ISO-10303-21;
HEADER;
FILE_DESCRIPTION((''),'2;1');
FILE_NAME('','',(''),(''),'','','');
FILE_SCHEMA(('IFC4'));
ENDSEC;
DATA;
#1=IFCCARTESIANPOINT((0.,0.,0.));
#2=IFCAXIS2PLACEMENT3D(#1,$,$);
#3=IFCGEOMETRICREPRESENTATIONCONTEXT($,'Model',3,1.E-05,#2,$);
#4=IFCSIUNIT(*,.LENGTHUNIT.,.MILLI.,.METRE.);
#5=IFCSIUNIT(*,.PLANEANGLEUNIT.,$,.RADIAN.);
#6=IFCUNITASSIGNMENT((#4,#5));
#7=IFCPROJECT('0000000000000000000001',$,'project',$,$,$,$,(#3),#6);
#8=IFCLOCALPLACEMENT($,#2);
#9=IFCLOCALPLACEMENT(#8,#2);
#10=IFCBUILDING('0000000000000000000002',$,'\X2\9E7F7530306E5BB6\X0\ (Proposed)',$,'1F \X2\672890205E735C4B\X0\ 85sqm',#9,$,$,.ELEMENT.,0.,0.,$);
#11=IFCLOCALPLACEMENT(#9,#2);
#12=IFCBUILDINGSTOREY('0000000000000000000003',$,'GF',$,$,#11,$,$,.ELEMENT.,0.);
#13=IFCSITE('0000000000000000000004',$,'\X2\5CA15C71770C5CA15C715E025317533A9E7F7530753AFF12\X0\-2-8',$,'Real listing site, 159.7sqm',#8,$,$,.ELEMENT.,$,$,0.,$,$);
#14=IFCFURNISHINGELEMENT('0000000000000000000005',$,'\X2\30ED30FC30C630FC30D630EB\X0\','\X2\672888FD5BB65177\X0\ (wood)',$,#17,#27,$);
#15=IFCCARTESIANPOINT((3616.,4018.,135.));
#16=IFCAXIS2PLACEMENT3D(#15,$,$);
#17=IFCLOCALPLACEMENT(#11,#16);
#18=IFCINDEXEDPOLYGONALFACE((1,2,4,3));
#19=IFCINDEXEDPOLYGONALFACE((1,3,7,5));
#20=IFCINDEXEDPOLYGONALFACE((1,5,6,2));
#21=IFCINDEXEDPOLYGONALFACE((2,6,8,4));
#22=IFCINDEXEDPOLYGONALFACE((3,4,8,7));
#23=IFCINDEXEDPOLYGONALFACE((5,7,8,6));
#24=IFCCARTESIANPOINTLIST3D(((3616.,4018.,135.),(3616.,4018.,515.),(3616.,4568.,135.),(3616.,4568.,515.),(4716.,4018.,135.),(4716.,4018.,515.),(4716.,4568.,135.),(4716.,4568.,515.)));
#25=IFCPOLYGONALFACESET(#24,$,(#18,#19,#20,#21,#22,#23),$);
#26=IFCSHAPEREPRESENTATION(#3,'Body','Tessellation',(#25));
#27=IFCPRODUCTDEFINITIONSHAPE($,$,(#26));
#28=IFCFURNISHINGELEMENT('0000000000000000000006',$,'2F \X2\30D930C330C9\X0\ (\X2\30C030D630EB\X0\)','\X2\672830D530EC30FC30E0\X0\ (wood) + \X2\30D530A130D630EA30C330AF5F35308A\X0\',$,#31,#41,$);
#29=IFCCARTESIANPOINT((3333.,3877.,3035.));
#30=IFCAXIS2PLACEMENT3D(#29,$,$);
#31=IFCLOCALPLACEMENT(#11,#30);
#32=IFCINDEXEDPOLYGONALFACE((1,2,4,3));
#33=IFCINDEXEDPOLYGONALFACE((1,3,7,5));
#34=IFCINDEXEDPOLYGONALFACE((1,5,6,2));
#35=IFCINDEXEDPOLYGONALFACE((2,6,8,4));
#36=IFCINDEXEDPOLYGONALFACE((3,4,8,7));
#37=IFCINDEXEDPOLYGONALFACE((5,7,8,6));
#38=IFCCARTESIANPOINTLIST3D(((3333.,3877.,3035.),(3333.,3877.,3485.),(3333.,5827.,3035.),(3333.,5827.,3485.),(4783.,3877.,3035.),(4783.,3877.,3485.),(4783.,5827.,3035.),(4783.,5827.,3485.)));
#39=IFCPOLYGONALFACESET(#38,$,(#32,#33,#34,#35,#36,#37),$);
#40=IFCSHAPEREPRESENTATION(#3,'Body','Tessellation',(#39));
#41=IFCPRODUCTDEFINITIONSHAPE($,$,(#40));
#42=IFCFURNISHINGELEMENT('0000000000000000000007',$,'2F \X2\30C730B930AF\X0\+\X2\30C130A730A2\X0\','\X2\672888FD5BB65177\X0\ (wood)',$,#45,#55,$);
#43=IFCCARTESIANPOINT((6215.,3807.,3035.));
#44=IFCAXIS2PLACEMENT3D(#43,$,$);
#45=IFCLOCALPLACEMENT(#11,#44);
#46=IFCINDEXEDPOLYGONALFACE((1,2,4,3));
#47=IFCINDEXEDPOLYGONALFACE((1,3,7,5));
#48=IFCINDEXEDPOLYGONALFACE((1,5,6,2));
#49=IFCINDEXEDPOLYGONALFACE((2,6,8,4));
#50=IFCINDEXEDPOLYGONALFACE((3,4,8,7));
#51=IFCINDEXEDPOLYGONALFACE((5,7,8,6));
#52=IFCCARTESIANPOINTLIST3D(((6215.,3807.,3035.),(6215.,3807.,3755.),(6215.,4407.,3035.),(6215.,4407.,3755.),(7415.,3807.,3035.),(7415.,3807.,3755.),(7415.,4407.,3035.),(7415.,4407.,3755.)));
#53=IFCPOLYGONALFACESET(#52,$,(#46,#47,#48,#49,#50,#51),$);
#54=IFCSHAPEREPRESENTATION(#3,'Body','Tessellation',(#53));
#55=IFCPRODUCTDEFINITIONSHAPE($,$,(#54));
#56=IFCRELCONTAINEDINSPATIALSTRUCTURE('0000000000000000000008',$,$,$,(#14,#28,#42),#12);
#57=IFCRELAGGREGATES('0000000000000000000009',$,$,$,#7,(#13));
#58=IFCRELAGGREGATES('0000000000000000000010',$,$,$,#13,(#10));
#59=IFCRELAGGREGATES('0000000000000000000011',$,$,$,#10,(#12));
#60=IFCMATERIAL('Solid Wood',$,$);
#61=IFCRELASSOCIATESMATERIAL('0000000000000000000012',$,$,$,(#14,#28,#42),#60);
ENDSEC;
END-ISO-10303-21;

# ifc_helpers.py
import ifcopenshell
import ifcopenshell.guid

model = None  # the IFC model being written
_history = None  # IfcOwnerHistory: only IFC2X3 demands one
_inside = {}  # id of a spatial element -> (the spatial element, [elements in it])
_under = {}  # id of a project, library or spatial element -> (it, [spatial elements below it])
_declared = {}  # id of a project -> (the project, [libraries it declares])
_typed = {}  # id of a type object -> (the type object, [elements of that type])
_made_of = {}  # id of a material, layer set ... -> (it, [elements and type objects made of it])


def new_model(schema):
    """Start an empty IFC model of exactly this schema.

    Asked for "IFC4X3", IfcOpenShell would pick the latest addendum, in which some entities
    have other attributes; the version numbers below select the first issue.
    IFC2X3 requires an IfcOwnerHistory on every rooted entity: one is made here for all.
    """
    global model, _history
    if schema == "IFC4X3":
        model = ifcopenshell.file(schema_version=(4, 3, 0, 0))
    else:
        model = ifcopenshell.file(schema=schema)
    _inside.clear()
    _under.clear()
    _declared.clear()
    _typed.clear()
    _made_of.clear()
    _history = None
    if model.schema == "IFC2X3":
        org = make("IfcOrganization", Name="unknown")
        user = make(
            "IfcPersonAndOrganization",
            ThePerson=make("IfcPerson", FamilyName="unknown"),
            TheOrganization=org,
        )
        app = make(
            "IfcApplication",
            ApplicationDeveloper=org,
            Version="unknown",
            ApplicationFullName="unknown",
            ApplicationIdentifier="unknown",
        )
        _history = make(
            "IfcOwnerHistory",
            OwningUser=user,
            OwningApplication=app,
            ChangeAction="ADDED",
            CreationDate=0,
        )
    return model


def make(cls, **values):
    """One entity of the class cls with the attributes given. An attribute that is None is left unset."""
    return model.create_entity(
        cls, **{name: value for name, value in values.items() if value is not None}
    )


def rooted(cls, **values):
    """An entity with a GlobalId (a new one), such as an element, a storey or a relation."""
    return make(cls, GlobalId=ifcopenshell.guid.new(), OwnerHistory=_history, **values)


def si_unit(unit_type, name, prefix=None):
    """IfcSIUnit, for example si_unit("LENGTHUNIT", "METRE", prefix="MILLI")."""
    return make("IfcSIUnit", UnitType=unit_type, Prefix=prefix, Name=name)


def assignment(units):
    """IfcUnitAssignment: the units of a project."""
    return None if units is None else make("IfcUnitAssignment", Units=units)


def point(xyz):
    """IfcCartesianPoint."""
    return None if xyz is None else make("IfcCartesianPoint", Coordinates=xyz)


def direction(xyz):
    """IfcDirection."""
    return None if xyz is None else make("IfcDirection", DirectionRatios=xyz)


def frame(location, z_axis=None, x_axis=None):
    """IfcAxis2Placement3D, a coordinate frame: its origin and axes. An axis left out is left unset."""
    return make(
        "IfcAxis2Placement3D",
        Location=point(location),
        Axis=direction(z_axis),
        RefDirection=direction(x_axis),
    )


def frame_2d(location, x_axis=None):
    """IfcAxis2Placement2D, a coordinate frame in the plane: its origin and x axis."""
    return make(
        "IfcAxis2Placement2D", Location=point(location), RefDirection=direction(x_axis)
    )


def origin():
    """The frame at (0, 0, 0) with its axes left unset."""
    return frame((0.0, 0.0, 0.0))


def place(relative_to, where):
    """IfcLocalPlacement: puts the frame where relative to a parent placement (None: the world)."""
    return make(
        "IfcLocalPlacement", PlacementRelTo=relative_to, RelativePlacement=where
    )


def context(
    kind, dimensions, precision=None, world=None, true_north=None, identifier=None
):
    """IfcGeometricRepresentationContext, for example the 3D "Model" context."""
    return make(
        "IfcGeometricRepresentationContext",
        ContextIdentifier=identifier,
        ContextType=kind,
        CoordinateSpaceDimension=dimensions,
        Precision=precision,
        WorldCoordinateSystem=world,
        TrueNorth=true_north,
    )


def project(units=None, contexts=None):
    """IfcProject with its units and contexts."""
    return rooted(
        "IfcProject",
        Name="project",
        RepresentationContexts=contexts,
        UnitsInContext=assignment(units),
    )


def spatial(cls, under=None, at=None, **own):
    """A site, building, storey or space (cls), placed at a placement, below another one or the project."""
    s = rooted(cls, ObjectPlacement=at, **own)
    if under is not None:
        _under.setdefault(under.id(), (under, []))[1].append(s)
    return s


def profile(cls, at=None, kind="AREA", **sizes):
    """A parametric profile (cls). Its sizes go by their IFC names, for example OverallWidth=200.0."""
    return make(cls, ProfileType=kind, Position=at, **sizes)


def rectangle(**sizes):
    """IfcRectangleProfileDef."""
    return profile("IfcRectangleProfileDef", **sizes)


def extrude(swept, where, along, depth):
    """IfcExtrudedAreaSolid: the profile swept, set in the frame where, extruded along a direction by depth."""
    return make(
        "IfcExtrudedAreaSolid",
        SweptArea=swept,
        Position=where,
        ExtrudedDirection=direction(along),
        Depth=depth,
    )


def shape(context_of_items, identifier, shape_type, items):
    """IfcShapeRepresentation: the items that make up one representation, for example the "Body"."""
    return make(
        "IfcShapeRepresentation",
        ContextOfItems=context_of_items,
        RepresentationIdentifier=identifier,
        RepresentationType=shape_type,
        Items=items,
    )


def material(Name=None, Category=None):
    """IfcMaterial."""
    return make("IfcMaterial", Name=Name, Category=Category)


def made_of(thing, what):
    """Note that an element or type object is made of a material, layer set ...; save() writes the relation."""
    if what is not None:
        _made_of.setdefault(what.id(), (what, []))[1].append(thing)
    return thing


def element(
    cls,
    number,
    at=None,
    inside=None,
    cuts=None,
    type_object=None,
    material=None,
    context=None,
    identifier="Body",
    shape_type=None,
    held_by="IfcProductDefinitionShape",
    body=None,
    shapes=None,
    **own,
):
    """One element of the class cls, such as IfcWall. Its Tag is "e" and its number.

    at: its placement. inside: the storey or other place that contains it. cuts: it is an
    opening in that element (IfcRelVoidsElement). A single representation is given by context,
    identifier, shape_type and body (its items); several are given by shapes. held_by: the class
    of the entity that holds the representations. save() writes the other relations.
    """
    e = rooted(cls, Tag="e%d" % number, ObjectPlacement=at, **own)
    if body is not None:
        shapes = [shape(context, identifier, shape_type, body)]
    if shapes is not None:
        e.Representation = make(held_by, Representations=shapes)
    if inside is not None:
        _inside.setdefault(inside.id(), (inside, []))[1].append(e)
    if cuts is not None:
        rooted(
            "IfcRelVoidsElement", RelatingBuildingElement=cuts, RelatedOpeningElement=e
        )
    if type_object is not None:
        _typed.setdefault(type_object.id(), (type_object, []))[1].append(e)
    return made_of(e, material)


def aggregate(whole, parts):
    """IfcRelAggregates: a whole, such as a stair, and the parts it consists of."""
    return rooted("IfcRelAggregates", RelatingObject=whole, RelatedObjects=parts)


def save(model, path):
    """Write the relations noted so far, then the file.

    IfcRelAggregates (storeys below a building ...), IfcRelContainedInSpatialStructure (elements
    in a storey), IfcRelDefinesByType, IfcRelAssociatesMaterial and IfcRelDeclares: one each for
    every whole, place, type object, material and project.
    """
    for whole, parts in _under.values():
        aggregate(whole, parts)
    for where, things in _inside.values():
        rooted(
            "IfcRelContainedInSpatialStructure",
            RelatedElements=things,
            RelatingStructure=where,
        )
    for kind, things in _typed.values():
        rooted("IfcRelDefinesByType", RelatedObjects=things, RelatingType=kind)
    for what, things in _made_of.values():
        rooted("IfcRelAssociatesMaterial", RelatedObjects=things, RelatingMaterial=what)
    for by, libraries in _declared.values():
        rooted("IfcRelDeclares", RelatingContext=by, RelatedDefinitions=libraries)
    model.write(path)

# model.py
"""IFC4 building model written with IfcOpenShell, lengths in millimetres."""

from ifc_helpers import new_model, si_unit, frame, frame_2d, origin, place, context, project, spatial, rectangle, extrude, material, element, save


model = new_model("IFC4")

# Units and contexts
model_context = context("Model", 3, precision=1e-05, world=origin())
ifc_project = project(units=[si_unit("LENGTHUNIT", "METRE", prefix="MILLI"), si_unit("PLANEANGLEUNIT", "RADIAN")], contexts=[model_context])

# Site, building, storey
site_placement = place(None, origin())
site = spatial("IfcSite", under=ifc_project, at=site_placement, Name="岡山県岡山市北区鹿田町２-2-8", ObjectType="Real listing site, 159.7sqm", CompositionType="ELEMENT", RefElevation=0.0)
building_placement = place(site_placement, origin())
building = spatial("IfcBuilding", under=site, at=building_placement, Name="鹿田の家 (Proposed)", ObjectType="1F 木造平屋 85sqm", CompositionType="ELEMENT", ElevationOfRefHeight=0.0, ElevationOfTerrain=0.0)
storey_placement = place(building_placement, origin())
storey = spatial("IfcBuildingStorey", under=building, at=storey_placement, Name="GF", CompositionType="ELEMENT", Elevation=0.0)

# Shared definitions
ifc_material_1 = material(Name="Solid Wood")

# Furnishing elements
furnishing_1_placement = place(storey_placement, frame((3616.0, 4018.0, 135.0)))
element("IfcFurnishingElement", 1, at=furnishing_1_placement, inside=storey, material=ifc_material_1, Name="ローテーブル", Description="木製家具 (wood)", context=model_context, shape_type="SweptSolid", body=[
    extrude(rectangle(XDim=1100.0, YDim=550.0, at=frame_2d((550.0, 275.0))), frame((3616.0, 4018.0, 135.0)), (0.0, 0.0, 1.0), 380.0),
])
furnishing_2_placement = place(storey_placement, frame((3333.0, 3877.0, 3035.0)))
element("IfcFurnishingElement", 2, at=furnishing_2_placement, inside=storey, material=ifc_material_1, Name="2F ベッド (ダブル)", Description="木フレーム (wood) + ファブリック張り", context=model_context, shape_type="SweptSolid", body=[
    extrude(rectangle(XDim=1450.0, YDim=1950.0, at=frame_2d((725.0, 975.0))), frame((3333.0, 3877.0, 3035.0)), (0.0, 0.0, 1.0), 450.0),
])
furnishing_3_placement = place(storey_placement, frame((6215.0, 3807.0, 3035.0)))
element("IfcFurnishingElement", 3, at=furnishing_3_placement, inside=storey, material=ifc_material_1, Name="2F デスク+チェア", Description="木製家具 (wood)", context=model_context, shape_type="SweptSolid", body=[
    extrude(rectangle(XDim=1200.0, YDim=600.0, at=frame_2d((600.0, 300.0))), frame((6215.0, 3807.0, 3035.0)), (0.0, 0.0, 1.0), 720.0),
])

save(model, "model.ifc")
